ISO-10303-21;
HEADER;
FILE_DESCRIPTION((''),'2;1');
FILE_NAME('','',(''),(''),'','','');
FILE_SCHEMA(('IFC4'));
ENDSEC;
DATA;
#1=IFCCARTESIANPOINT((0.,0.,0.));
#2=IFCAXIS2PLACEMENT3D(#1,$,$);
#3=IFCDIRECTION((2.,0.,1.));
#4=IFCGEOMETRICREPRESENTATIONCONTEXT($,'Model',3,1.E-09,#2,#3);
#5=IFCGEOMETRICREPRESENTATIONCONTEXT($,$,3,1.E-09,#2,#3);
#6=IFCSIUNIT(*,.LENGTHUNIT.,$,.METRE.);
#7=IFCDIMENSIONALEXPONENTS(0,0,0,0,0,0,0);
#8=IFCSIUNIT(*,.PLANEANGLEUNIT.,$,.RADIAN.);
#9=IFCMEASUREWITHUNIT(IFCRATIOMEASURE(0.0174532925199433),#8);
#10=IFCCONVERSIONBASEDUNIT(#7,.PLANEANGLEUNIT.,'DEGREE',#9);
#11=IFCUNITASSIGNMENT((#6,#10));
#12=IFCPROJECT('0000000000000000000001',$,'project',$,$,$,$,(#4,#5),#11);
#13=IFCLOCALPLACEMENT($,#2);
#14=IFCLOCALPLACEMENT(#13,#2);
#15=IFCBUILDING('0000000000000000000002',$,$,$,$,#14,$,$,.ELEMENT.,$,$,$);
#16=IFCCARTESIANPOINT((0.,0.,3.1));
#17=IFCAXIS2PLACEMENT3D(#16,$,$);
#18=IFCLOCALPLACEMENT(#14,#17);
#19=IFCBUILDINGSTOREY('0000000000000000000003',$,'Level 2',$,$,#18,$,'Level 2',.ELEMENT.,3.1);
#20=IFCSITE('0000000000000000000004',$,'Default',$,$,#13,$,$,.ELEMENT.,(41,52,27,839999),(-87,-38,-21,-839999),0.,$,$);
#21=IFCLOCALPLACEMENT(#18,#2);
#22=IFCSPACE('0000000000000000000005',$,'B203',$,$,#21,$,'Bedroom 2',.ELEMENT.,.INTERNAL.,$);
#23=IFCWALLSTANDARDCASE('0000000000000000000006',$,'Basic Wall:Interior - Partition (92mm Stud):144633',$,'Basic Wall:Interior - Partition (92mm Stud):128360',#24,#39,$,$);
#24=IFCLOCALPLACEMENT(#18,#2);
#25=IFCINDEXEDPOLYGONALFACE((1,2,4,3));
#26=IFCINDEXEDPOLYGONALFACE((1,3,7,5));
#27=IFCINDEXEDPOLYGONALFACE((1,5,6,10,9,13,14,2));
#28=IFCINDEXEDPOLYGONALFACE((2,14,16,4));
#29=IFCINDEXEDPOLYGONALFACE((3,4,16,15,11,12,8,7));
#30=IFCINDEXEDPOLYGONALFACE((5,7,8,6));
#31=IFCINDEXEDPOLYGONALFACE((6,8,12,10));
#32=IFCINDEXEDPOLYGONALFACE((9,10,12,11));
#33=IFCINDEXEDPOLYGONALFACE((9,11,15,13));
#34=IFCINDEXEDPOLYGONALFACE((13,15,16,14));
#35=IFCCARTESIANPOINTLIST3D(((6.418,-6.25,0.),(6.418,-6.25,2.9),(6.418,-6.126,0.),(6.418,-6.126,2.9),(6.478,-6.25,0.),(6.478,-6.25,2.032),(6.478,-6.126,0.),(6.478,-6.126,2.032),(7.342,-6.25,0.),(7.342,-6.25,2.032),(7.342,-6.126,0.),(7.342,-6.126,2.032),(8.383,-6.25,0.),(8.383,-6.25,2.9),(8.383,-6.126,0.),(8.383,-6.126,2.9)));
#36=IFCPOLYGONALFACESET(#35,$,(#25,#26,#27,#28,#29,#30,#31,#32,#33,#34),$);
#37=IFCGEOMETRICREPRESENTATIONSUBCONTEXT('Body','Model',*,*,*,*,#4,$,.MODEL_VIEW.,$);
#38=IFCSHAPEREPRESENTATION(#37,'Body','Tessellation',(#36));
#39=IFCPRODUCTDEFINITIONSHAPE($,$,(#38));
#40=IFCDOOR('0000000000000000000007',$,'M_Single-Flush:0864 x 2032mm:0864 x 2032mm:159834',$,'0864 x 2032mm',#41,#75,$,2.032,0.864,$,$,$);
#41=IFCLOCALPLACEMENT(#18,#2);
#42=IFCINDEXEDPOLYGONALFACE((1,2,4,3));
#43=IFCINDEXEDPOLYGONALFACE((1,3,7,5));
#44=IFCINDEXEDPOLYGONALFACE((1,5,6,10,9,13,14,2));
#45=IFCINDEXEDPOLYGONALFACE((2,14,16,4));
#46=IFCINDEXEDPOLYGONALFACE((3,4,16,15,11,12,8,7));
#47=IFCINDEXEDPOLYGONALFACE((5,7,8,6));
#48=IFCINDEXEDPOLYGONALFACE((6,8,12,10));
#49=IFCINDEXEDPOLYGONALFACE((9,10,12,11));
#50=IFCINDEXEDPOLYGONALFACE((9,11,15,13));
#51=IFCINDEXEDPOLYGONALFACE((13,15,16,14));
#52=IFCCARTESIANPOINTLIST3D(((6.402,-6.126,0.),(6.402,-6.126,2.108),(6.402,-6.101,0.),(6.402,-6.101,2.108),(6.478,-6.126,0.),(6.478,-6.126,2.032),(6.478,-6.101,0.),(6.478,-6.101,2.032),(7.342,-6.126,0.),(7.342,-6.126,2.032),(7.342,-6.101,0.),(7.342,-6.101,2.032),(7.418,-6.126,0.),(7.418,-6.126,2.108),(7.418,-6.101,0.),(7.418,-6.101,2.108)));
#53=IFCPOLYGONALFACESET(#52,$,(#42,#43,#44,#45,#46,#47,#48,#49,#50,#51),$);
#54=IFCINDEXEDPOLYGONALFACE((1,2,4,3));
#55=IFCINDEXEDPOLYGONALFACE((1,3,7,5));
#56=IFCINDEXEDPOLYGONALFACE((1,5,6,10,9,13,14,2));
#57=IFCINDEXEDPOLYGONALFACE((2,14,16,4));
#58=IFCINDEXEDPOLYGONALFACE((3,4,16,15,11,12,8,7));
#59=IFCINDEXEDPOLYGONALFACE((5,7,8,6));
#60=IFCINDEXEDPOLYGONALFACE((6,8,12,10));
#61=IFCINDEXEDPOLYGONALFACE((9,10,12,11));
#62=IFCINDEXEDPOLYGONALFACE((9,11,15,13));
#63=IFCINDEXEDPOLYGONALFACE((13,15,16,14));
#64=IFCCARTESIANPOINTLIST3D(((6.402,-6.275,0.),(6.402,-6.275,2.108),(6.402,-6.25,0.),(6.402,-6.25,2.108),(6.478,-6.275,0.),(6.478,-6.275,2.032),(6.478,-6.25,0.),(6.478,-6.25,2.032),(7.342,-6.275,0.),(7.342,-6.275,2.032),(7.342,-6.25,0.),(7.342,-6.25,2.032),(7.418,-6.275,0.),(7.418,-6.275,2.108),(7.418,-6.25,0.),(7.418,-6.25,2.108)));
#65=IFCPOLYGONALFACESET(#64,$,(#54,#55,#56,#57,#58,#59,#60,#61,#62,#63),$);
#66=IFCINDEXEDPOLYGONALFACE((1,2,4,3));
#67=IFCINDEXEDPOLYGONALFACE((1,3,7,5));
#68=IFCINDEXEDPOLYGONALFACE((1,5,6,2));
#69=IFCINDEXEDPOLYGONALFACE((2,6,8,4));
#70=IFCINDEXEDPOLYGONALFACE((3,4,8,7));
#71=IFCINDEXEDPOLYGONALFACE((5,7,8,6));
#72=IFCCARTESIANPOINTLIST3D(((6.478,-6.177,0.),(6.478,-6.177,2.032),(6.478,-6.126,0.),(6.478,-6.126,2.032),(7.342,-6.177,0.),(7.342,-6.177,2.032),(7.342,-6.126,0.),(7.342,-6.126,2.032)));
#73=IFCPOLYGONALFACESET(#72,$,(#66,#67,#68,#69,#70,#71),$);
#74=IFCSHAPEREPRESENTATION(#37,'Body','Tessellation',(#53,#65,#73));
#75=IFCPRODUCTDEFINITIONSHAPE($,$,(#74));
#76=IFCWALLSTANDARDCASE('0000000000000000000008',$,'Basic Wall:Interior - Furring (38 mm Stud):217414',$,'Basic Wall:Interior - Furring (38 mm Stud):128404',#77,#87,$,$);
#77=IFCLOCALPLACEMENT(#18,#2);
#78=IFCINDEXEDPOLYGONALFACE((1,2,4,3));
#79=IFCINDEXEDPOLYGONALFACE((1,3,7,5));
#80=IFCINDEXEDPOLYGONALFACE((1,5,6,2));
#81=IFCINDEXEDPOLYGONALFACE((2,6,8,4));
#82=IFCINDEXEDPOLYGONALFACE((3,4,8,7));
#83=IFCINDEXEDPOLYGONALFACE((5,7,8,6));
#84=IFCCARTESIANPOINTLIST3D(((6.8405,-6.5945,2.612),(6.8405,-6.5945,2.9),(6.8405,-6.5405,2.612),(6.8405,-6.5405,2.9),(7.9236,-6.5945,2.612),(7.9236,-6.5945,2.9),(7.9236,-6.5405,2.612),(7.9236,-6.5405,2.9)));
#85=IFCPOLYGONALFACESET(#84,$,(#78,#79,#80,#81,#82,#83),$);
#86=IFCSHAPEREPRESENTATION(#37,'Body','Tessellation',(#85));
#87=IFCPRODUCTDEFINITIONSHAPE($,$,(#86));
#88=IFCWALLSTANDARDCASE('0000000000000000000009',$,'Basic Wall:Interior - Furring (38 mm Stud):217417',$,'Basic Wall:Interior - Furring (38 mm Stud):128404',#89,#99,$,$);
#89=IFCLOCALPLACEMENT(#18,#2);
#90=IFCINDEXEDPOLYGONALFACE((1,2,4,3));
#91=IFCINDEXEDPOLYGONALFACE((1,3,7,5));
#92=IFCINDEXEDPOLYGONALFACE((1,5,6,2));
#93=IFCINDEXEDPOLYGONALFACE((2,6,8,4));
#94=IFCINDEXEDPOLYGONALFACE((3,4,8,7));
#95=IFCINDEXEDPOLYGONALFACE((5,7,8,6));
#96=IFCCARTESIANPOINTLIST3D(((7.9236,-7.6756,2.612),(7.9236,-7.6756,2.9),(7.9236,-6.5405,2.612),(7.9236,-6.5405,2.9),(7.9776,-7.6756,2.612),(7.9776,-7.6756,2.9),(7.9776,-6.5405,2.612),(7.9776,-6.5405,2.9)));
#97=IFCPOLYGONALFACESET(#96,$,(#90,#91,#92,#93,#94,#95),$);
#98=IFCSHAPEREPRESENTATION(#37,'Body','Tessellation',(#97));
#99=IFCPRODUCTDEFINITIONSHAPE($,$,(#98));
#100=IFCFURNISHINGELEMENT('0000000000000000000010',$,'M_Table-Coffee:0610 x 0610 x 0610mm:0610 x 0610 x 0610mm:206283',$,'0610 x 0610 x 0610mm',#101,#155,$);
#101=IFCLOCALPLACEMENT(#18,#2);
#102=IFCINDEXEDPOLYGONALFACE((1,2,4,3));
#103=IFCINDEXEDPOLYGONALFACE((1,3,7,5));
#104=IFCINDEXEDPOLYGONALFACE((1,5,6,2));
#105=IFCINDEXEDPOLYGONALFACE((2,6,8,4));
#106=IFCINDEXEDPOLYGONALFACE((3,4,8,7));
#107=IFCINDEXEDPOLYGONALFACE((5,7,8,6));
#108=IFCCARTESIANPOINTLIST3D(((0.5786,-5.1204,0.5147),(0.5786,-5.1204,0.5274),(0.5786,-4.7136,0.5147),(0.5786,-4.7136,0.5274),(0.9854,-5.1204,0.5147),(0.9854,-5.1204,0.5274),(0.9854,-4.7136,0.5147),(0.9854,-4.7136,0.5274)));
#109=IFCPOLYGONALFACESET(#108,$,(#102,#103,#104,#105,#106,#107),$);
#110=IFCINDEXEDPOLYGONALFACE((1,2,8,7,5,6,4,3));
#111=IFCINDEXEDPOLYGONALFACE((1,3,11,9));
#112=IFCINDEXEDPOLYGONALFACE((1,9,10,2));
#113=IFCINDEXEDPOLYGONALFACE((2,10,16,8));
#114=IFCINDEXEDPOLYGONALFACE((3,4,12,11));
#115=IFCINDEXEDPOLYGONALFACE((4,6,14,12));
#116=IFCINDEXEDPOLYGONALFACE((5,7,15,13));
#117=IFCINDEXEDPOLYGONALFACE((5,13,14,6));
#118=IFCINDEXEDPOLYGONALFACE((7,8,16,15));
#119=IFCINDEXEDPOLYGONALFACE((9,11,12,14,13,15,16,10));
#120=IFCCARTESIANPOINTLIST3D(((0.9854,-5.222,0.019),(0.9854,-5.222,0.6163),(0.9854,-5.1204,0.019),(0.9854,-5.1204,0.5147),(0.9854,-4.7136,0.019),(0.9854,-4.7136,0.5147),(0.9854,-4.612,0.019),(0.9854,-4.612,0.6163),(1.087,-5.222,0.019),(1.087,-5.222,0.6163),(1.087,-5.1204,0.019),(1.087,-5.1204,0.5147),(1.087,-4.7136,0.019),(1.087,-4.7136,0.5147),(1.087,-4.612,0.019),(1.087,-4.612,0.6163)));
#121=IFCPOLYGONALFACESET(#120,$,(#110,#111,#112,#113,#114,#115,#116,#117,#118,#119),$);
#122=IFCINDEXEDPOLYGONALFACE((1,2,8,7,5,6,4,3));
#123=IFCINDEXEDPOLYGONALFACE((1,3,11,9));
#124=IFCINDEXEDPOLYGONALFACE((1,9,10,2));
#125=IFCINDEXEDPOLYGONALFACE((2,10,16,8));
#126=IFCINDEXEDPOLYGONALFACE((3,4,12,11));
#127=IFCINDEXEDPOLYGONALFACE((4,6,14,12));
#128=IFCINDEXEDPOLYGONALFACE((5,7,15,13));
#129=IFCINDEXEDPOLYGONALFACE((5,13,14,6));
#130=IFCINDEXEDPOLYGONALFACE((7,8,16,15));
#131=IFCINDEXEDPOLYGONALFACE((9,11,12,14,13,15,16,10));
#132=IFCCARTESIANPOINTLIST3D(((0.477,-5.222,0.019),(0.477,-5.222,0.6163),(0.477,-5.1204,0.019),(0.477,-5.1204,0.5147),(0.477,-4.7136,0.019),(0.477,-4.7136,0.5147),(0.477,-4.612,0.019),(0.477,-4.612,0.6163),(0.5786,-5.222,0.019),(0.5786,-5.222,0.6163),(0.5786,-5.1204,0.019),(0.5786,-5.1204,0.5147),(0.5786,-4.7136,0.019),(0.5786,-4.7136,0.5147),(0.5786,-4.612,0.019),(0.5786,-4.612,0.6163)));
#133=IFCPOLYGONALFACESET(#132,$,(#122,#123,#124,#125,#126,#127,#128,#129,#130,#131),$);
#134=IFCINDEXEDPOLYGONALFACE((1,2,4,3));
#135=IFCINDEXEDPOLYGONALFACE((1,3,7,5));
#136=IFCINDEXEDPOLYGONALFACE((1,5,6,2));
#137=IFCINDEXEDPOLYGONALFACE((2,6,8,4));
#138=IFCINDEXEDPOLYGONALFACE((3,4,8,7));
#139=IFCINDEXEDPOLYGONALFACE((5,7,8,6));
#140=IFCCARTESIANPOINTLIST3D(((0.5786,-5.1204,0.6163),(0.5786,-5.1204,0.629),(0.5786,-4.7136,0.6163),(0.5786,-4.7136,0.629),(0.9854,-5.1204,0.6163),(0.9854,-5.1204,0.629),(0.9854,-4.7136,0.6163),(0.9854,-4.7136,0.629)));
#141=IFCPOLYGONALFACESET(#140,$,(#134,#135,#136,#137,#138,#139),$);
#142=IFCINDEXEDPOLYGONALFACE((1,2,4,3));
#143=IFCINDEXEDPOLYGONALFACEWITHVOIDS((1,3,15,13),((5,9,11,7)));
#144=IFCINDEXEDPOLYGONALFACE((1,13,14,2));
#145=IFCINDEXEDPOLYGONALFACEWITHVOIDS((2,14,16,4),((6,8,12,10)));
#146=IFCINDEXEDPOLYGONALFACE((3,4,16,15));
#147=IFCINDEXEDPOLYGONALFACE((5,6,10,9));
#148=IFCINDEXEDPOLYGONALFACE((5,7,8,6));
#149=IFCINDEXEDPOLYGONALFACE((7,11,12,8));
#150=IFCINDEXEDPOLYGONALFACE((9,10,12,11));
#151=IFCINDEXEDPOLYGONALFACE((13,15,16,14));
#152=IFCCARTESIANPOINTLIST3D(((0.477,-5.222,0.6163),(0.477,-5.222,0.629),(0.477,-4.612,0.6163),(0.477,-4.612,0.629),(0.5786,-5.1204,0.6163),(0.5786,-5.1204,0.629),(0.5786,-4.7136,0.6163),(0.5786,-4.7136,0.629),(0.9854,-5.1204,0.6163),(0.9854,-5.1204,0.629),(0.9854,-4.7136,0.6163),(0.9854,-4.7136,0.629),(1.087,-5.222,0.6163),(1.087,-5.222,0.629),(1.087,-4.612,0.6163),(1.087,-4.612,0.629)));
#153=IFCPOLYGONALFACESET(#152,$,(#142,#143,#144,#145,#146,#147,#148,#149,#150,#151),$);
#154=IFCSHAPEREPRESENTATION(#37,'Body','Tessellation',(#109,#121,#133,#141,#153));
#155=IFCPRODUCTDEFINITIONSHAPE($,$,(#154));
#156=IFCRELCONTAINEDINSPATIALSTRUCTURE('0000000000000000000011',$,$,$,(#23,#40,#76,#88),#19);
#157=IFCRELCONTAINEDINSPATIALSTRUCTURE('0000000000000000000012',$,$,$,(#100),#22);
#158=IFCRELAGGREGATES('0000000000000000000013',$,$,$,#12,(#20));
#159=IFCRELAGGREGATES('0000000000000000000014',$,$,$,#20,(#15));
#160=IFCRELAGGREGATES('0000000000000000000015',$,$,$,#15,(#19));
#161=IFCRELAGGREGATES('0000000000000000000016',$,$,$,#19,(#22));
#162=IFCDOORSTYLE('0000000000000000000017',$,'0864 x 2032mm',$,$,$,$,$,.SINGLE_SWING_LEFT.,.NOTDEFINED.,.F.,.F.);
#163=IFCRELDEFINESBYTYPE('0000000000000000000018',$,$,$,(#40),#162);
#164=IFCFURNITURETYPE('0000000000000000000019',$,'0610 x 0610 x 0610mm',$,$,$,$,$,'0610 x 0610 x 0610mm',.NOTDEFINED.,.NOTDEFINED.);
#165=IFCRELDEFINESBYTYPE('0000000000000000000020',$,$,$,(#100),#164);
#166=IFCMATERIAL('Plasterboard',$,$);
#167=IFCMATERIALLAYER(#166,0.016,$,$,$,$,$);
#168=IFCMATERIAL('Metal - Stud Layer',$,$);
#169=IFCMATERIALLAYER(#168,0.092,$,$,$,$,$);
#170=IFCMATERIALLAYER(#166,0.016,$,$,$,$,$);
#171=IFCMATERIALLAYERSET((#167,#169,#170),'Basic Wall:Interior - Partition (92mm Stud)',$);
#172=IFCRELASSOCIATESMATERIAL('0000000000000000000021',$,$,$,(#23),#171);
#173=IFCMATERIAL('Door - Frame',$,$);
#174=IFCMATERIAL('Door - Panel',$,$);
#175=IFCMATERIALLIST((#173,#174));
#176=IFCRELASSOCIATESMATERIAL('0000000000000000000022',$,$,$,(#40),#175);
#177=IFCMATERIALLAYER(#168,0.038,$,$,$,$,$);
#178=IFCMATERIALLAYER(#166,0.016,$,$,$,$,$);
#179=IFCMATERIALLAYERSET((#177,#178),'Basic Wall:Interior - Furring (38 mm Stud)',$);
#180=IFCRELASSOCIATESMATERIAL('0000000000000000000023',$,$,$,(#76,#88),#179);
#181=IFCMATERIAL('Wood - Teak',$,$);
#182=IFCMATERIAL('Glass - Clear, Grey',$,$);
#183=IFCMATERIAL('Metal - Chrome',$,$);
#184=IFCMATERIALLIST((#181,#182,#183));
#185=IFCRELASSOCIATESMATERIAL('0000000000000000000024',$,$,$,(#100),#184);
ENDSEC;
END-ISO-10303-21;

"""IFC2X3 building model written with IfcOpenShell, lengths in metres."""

from ifc_helpers import new_model, entity, si_unit, converted_unit, direction, frame, frame_2d, origin, origin_2d_with_axis, place, context, subcontext, project, spatial, polyline, rectangle, outline, extrude, source, transform, mapped, material, material_list, layer, layer_set, layer_usage, type_object, type_shapes, element, fill, save


model = new_model("IFC2X3")

# Units and contexts
model_context = context("Model", 3, precision=1e-09, world=origin(), true_north=direction((2.0, 0.0, 1.0)))
context_of_model = context(None, 3, precision=1e-09, world=origin(), true_north=direction((2.0, 0.0, 1.0)))
body_context = subcontext(model_context, "Body", "Model", "MODEL_VIEW")
ifc_project = project(units=[si_unit("LENGTHUNIT", "METRE"), converted_unit("PLANEANGLEUNIT", "DEGREE", entity("IfcRatioMeasure", 0.0174532925199433), si_unit("PLANEANGLEUNIT", "RADIAN"), dimensions=[0, 0, 0, 0, 0, 0, 0])], contexts=[model_context, context_of_model])

# Site, building, storey
site_placement = place(None, origin())
site = spatial("IfcSite", under=ifc_project, at=site_placement, Name="Default", CompositionType="ELEMENT", RefLatitude=(41, 52, 27, 839999), RefLongitude=(-87, -38, -21, -839999), RefElevation=0.0)
building_placement = place(site_placement, origin())
building = spatial("IfcBuilding", under=site, at=building_placement, CompositionType="ELEMENT")
storey_placement = place(building_placement, frame((0.0, 0.0, 3.1)))
storey = spatial("IfcBuildingStorey", under=building, at=storey_placement, Name="Level 2", LongName="Level 2", CompositionType="ELEMENT", Elevation=3.1)

# Shared definitions
ifc_material_1 = material(Name="Metal - Stud Layer")
ifc_material_2 = material(Name="Plasterboard")

# Wall, opening, door
ifc_layer_1 = layer(ifc_material_2, 0.016)
ifc_layer_2 = layer(ifc_material_1, 0.092)
ifc_layer_3 = layer(ifc_material_2, 0.016)
ifc_layer_set_1 = layer_set([ifc_layer_1, ifc_layer_2, ifc_layer_3], Name="Basic Wall:Interior - Partition (92mm Stud)")
ifc_material_3 = material(Name="Door - Frame")
ifc_material_4 = material(Name="Door - Panel")
ifc_layer_usage_1 = layer_usage(ifc_layer_set_1, "AXIS2", "NEGATIVE", 0.062)
wall_1_placement = place(storey_placement, frame((6.418, -6.188, 0.0)))
wall_1 = element("IfcWallStandardCase", 1, at=wall_1_placement, inside=storey, material=ifc_layer_usage_1, Name="Basic Wall:Interior - Partition (92mm Stud):144633", ObjectType="Basic Wall:Interior - Partition (92mm Stud):128360", context=body_context, shape_type="SweptSolid", body=[
    extrude(rectangle(XDim=1.965, YDim=0.124, at=frame_2d((0.9825, 0.0), x_axis=(-1.0, 0.0))), origin(), (0.0, 0.0, 1.0), 2.9),
])
opening_1_placement = place(wall_1_placement, frame((0.06, -0.062, 0.0)))
opening_1 = element("IfcOpeningElement", 2, at=opening_1_placement, cuts=wall_1, ObjectType="Opening", context=body_context, shape_type="SweptSolid", body=[
    extrude(rectangle(XDim=0.864, YDim=2.032, at=frame_2d((1.016, 0.432), x_axis=(0.0, -1.0))), frame((0.0, 0.0, 0.0), z_axis=(0.0, 1.0, 0.0), x_axis=(0.0, 0.0, 1.0)), (0.0, 0.0, 1.0), 0.124),
])
ifc_material_list_1 = material_list([ifc_material_3, ifc_material_4])
door_style_1 = type_object("IfcDoorStyle", Name="0864 x 2032mm", ConstructionType="NOTDEFINED", OperationType="SINGLE_SWING_LEFT", ParameterTakesPrecedence=False, Sizeable=False)
shared_shape_1 = source(origin(), body_context, "Body", "SweptSolid", [
    extrude(outline(polyline([(-0.508, -1.073), (0.508, -1.073), (0.508, 1.035), (0.432, 1.035), (0.432, -0.997), (-0.432, -0.997), (-0.432, 1.035), (-0.508, 1.035), (-0.508, -1.073)])), frame((0.432, 0.149, 1.035), z_axis=(0.0, -1.0, 0.0), x_axis=(-1.0, 0.0, 0.0)), (0.0, 0.0, 1.0), 0.025),
    extrude(outline(polyline([(-1.073, -0.508), (1.035, -0.508), (1.035, -0.432), (-0.997, -0.432), (-0.997, 0.432), (1.035, 0.432), (1.035, 0.508), (-1.073, 0.508), (-1.073, -0.508)])), frame((0.432, 0.0, 1.035), z_axis=(0.0, -1.0, 0.0), x_axis=(0.0, 0.0, -1.0)), (0.0, 0.0, 1.0), 0.025),
    extrude(rectangle(XDim=0.864, YDim=0.051, at=frame_2d((0.0, 0.0), x_axis=(1.0, 0.0))), frame((0.432, 0.0985, 0.0)), (0.0, 0.0, 1.0), 2.032),
])
type_shapes(door_style_1, [shared_shape_1])
door_1_placement = place(opening_1_placement, origin())
door_1 = element("IfcDoor", 3, at=door_1_placement, inside=storey, type_object=door_style_1, material=ifc_material_list_1, Name="M_Single-Flush:0864 x 2032mm:0864 x 2032mm:159834", ObjectType="0864 x 2032mm", OverallHeight=2.032, OverallWidth=0.864, context=body_context, shape_type="MappedRepresentation", body=[
    mapped(shared_shape_1, transform((0.0, 0.0, 0.0), scale=1.0)),
])
fill(opening_1, door_1)

# Walls
ifc_layer_4 = layer(ifc_material_1, 0.038)
ifc_layer_5 = layer(ifc_material_2, 0.016)
ifc_layer_set_2 = layer_set([ifc_layer_4, ifc_layer_5], Name="Basic Wall:Interior - Furring (38 mm Stud)")
ifc_layer_usage_2 = layer_usage(ifc_layer_set_2, "AXIS2", "NEGATIVE", 0.027)
wall_2_placement = place(storey_placement, frame((6.8405, -6.5675, 2.612)))
element("IfcWallStandardCase", 4, at=wall_2_placement, inside=storey, material=ifc_layer_usage_2, Name="Basic Wall:Interior - Furring (38 mm Stud):217414", ObjectType="Basic Wall:Interior - Furring (38 mm Stud):128404", context=body_context, shape_type="SweptSolid", body=[
    extrude(rectangle(XDim=1.0831, YDim=0.054, at=frame_2d((0.5415, 0.0), x_axis=(-1.0, 0.0))), origin(), (0.0, 0.0, 1.0), 0.288),
])
ifc_layer_usage_3 = layer_usage(ifc_layer_set_2, "AXIS2", "NEGATIVE", 0.027)
wall_3_placement = place(storey_placement, frame((7.9506, -6.5405, 2.612), z_axis=(0.0, 0.0, 1.0), x_axis=(0.0, -1.0, 0.0)))
element("IfcWallStandardCase", 5, at=wall_3_placement, inside=storey, material=ifc_layer_usage_3, Name="Basic Wall:Interior - Furring (38 mm Stud):217417", ObjectType="Basic Wall:Interior - Furring (38 mm Stud):128404", context=body_context, shape_type="SweptSolid", body=[
    extrude(rectangle(XDim=1.1351, YDim=0.054, at=frame_2d((0.5675, 0.0), x_axis=(-1.0, 0.0))), origin(), (0.0, 0.0, 1.0), 0.288),
])

# Shared definitions
space_1_placement = place(storey_placement, origin())
space_1 = spatial("IfcSpace", under=storey, at=space_1_placement, Name="B203", LongName="Bedroom 2", CompositionType="ELEMENT", InteriorOrExteriorSpace="INTERNAL")

# Furnishing element
ifc_material_5 = material(Name="Wood - Teak")
ifc_material_6 = material(Name="Glass - Clear, Grey")
ifc_material_7 = material(Name="Metal - Chrome")
ifc_material_list_2 = material_list([ifc_material_5, ifc_material_6, ifc_material_7])
furniture_type_1 = type_object("IfcFurnitureType", Name="0610 x 0610 x 0610mm", ElementType="0610 x 0610 x 0610mm", AssemblyPlace="NOTDEFINED")
shared_shape_2 = source(origin(), body_context, "Body", "SweptSolid", [
    extrude(rectangle(XDim=0.4068, YDim=0.4068, at=origin_2d_with_axis()), frame((0.0183, 0.0952, 0.4957), z_axis=(0.0, 0.0, 1.0), x_axis=(-1.0, 0.0, 0.0)), (0.0, 0.0, 1.0), 0.0127),
    extrude(outline(polyline([(-0.2732, -0.305), (0.324, -0.305), (0.324, 0.305), (-0.2732, 0.305), (-0.2732, 0.2034), (0.2225, 0.2034), (0.2225, -0.2034), (-0.2732, -0.2034), (-0.2732, -0.305)])), frame((0.2217, 0.0952, 0.2732), z_axis=(1.0, 0.0, 0.0), x_axis=(0.0, 0.0, 1.0)), (0.0, 0.0, 1.0), 0.1016),
    extrude(outline(polyline([(-0.305, -0.3241), (0.305, -0.3241), (0.305, 0.2733), (0.2034, 0.2733), (0.2034, -0.2224), (-0.2034, -0.2224), (-0.2034, 0.2733), (-0.305, 0.2733), (-0.305, -0.3241)])), frame((-0.2867, 0.0952, 0.2733), z_axis=(1.0, 0.0, 0.0), x_axis=(0.0, -1.0, 0.0)), (0.0, 0.0, 1.0), 0.1016),
    extrude(rectangle(XDim=0.4068, YDim=0.4068, at=origin_2d_with_axis()), frame((0.0183, 0.0952, 0.5973), z_axis=(0.0, 0.0, 1.0), x_axis=(-1.0, 0.0, 0.0)), (0.0, 0.0, 1.0), 0.0127),
    extrude(outline(polyline([(-0.305, -0.305), (0.305, -0.305), (0.305, 0.305), (-0.305, 0.305), (-0.305, -0.305)]), holes=[polyline([(-0.2034, -0.2034), (-0.2034, 0.2034), (0.2034, 0.2034), (0.2034, -0.2034), (-0.2034, -0.2034)])]), frame((0.0183, 0.0952, 0.5973), z_axis=(0.0, 0.0, 1.0), x_axis=(-1.0, 0.0, 0.0)), (0.0, 0.0, 1.0), 0.0127),
])
type_shapes(furniture_type_1, [shared_shape_2])
furnishing_1_placement = place(space_1_placement, frame((0.7637, -5.0122, 0.019)))
element("IfcFurnishingElement", 6, at=furnishing_1_placement, inside=space_1, type_object=furniture_type_1, material=ifc_material_list_2, Name="M_Table-Coffee:0610 x 0610 x 0610mm:0610 x 0610 x 0610mm:206283", ObjectType="0610 x 0610 x 0610mm", context=body_context, shape_type="MappedRepresentation", body=[
    mapped(shared_shape_2, transform((0.0, 0.0, 0.0), scale=1.0)),
])

save(model, "model.ifc")
